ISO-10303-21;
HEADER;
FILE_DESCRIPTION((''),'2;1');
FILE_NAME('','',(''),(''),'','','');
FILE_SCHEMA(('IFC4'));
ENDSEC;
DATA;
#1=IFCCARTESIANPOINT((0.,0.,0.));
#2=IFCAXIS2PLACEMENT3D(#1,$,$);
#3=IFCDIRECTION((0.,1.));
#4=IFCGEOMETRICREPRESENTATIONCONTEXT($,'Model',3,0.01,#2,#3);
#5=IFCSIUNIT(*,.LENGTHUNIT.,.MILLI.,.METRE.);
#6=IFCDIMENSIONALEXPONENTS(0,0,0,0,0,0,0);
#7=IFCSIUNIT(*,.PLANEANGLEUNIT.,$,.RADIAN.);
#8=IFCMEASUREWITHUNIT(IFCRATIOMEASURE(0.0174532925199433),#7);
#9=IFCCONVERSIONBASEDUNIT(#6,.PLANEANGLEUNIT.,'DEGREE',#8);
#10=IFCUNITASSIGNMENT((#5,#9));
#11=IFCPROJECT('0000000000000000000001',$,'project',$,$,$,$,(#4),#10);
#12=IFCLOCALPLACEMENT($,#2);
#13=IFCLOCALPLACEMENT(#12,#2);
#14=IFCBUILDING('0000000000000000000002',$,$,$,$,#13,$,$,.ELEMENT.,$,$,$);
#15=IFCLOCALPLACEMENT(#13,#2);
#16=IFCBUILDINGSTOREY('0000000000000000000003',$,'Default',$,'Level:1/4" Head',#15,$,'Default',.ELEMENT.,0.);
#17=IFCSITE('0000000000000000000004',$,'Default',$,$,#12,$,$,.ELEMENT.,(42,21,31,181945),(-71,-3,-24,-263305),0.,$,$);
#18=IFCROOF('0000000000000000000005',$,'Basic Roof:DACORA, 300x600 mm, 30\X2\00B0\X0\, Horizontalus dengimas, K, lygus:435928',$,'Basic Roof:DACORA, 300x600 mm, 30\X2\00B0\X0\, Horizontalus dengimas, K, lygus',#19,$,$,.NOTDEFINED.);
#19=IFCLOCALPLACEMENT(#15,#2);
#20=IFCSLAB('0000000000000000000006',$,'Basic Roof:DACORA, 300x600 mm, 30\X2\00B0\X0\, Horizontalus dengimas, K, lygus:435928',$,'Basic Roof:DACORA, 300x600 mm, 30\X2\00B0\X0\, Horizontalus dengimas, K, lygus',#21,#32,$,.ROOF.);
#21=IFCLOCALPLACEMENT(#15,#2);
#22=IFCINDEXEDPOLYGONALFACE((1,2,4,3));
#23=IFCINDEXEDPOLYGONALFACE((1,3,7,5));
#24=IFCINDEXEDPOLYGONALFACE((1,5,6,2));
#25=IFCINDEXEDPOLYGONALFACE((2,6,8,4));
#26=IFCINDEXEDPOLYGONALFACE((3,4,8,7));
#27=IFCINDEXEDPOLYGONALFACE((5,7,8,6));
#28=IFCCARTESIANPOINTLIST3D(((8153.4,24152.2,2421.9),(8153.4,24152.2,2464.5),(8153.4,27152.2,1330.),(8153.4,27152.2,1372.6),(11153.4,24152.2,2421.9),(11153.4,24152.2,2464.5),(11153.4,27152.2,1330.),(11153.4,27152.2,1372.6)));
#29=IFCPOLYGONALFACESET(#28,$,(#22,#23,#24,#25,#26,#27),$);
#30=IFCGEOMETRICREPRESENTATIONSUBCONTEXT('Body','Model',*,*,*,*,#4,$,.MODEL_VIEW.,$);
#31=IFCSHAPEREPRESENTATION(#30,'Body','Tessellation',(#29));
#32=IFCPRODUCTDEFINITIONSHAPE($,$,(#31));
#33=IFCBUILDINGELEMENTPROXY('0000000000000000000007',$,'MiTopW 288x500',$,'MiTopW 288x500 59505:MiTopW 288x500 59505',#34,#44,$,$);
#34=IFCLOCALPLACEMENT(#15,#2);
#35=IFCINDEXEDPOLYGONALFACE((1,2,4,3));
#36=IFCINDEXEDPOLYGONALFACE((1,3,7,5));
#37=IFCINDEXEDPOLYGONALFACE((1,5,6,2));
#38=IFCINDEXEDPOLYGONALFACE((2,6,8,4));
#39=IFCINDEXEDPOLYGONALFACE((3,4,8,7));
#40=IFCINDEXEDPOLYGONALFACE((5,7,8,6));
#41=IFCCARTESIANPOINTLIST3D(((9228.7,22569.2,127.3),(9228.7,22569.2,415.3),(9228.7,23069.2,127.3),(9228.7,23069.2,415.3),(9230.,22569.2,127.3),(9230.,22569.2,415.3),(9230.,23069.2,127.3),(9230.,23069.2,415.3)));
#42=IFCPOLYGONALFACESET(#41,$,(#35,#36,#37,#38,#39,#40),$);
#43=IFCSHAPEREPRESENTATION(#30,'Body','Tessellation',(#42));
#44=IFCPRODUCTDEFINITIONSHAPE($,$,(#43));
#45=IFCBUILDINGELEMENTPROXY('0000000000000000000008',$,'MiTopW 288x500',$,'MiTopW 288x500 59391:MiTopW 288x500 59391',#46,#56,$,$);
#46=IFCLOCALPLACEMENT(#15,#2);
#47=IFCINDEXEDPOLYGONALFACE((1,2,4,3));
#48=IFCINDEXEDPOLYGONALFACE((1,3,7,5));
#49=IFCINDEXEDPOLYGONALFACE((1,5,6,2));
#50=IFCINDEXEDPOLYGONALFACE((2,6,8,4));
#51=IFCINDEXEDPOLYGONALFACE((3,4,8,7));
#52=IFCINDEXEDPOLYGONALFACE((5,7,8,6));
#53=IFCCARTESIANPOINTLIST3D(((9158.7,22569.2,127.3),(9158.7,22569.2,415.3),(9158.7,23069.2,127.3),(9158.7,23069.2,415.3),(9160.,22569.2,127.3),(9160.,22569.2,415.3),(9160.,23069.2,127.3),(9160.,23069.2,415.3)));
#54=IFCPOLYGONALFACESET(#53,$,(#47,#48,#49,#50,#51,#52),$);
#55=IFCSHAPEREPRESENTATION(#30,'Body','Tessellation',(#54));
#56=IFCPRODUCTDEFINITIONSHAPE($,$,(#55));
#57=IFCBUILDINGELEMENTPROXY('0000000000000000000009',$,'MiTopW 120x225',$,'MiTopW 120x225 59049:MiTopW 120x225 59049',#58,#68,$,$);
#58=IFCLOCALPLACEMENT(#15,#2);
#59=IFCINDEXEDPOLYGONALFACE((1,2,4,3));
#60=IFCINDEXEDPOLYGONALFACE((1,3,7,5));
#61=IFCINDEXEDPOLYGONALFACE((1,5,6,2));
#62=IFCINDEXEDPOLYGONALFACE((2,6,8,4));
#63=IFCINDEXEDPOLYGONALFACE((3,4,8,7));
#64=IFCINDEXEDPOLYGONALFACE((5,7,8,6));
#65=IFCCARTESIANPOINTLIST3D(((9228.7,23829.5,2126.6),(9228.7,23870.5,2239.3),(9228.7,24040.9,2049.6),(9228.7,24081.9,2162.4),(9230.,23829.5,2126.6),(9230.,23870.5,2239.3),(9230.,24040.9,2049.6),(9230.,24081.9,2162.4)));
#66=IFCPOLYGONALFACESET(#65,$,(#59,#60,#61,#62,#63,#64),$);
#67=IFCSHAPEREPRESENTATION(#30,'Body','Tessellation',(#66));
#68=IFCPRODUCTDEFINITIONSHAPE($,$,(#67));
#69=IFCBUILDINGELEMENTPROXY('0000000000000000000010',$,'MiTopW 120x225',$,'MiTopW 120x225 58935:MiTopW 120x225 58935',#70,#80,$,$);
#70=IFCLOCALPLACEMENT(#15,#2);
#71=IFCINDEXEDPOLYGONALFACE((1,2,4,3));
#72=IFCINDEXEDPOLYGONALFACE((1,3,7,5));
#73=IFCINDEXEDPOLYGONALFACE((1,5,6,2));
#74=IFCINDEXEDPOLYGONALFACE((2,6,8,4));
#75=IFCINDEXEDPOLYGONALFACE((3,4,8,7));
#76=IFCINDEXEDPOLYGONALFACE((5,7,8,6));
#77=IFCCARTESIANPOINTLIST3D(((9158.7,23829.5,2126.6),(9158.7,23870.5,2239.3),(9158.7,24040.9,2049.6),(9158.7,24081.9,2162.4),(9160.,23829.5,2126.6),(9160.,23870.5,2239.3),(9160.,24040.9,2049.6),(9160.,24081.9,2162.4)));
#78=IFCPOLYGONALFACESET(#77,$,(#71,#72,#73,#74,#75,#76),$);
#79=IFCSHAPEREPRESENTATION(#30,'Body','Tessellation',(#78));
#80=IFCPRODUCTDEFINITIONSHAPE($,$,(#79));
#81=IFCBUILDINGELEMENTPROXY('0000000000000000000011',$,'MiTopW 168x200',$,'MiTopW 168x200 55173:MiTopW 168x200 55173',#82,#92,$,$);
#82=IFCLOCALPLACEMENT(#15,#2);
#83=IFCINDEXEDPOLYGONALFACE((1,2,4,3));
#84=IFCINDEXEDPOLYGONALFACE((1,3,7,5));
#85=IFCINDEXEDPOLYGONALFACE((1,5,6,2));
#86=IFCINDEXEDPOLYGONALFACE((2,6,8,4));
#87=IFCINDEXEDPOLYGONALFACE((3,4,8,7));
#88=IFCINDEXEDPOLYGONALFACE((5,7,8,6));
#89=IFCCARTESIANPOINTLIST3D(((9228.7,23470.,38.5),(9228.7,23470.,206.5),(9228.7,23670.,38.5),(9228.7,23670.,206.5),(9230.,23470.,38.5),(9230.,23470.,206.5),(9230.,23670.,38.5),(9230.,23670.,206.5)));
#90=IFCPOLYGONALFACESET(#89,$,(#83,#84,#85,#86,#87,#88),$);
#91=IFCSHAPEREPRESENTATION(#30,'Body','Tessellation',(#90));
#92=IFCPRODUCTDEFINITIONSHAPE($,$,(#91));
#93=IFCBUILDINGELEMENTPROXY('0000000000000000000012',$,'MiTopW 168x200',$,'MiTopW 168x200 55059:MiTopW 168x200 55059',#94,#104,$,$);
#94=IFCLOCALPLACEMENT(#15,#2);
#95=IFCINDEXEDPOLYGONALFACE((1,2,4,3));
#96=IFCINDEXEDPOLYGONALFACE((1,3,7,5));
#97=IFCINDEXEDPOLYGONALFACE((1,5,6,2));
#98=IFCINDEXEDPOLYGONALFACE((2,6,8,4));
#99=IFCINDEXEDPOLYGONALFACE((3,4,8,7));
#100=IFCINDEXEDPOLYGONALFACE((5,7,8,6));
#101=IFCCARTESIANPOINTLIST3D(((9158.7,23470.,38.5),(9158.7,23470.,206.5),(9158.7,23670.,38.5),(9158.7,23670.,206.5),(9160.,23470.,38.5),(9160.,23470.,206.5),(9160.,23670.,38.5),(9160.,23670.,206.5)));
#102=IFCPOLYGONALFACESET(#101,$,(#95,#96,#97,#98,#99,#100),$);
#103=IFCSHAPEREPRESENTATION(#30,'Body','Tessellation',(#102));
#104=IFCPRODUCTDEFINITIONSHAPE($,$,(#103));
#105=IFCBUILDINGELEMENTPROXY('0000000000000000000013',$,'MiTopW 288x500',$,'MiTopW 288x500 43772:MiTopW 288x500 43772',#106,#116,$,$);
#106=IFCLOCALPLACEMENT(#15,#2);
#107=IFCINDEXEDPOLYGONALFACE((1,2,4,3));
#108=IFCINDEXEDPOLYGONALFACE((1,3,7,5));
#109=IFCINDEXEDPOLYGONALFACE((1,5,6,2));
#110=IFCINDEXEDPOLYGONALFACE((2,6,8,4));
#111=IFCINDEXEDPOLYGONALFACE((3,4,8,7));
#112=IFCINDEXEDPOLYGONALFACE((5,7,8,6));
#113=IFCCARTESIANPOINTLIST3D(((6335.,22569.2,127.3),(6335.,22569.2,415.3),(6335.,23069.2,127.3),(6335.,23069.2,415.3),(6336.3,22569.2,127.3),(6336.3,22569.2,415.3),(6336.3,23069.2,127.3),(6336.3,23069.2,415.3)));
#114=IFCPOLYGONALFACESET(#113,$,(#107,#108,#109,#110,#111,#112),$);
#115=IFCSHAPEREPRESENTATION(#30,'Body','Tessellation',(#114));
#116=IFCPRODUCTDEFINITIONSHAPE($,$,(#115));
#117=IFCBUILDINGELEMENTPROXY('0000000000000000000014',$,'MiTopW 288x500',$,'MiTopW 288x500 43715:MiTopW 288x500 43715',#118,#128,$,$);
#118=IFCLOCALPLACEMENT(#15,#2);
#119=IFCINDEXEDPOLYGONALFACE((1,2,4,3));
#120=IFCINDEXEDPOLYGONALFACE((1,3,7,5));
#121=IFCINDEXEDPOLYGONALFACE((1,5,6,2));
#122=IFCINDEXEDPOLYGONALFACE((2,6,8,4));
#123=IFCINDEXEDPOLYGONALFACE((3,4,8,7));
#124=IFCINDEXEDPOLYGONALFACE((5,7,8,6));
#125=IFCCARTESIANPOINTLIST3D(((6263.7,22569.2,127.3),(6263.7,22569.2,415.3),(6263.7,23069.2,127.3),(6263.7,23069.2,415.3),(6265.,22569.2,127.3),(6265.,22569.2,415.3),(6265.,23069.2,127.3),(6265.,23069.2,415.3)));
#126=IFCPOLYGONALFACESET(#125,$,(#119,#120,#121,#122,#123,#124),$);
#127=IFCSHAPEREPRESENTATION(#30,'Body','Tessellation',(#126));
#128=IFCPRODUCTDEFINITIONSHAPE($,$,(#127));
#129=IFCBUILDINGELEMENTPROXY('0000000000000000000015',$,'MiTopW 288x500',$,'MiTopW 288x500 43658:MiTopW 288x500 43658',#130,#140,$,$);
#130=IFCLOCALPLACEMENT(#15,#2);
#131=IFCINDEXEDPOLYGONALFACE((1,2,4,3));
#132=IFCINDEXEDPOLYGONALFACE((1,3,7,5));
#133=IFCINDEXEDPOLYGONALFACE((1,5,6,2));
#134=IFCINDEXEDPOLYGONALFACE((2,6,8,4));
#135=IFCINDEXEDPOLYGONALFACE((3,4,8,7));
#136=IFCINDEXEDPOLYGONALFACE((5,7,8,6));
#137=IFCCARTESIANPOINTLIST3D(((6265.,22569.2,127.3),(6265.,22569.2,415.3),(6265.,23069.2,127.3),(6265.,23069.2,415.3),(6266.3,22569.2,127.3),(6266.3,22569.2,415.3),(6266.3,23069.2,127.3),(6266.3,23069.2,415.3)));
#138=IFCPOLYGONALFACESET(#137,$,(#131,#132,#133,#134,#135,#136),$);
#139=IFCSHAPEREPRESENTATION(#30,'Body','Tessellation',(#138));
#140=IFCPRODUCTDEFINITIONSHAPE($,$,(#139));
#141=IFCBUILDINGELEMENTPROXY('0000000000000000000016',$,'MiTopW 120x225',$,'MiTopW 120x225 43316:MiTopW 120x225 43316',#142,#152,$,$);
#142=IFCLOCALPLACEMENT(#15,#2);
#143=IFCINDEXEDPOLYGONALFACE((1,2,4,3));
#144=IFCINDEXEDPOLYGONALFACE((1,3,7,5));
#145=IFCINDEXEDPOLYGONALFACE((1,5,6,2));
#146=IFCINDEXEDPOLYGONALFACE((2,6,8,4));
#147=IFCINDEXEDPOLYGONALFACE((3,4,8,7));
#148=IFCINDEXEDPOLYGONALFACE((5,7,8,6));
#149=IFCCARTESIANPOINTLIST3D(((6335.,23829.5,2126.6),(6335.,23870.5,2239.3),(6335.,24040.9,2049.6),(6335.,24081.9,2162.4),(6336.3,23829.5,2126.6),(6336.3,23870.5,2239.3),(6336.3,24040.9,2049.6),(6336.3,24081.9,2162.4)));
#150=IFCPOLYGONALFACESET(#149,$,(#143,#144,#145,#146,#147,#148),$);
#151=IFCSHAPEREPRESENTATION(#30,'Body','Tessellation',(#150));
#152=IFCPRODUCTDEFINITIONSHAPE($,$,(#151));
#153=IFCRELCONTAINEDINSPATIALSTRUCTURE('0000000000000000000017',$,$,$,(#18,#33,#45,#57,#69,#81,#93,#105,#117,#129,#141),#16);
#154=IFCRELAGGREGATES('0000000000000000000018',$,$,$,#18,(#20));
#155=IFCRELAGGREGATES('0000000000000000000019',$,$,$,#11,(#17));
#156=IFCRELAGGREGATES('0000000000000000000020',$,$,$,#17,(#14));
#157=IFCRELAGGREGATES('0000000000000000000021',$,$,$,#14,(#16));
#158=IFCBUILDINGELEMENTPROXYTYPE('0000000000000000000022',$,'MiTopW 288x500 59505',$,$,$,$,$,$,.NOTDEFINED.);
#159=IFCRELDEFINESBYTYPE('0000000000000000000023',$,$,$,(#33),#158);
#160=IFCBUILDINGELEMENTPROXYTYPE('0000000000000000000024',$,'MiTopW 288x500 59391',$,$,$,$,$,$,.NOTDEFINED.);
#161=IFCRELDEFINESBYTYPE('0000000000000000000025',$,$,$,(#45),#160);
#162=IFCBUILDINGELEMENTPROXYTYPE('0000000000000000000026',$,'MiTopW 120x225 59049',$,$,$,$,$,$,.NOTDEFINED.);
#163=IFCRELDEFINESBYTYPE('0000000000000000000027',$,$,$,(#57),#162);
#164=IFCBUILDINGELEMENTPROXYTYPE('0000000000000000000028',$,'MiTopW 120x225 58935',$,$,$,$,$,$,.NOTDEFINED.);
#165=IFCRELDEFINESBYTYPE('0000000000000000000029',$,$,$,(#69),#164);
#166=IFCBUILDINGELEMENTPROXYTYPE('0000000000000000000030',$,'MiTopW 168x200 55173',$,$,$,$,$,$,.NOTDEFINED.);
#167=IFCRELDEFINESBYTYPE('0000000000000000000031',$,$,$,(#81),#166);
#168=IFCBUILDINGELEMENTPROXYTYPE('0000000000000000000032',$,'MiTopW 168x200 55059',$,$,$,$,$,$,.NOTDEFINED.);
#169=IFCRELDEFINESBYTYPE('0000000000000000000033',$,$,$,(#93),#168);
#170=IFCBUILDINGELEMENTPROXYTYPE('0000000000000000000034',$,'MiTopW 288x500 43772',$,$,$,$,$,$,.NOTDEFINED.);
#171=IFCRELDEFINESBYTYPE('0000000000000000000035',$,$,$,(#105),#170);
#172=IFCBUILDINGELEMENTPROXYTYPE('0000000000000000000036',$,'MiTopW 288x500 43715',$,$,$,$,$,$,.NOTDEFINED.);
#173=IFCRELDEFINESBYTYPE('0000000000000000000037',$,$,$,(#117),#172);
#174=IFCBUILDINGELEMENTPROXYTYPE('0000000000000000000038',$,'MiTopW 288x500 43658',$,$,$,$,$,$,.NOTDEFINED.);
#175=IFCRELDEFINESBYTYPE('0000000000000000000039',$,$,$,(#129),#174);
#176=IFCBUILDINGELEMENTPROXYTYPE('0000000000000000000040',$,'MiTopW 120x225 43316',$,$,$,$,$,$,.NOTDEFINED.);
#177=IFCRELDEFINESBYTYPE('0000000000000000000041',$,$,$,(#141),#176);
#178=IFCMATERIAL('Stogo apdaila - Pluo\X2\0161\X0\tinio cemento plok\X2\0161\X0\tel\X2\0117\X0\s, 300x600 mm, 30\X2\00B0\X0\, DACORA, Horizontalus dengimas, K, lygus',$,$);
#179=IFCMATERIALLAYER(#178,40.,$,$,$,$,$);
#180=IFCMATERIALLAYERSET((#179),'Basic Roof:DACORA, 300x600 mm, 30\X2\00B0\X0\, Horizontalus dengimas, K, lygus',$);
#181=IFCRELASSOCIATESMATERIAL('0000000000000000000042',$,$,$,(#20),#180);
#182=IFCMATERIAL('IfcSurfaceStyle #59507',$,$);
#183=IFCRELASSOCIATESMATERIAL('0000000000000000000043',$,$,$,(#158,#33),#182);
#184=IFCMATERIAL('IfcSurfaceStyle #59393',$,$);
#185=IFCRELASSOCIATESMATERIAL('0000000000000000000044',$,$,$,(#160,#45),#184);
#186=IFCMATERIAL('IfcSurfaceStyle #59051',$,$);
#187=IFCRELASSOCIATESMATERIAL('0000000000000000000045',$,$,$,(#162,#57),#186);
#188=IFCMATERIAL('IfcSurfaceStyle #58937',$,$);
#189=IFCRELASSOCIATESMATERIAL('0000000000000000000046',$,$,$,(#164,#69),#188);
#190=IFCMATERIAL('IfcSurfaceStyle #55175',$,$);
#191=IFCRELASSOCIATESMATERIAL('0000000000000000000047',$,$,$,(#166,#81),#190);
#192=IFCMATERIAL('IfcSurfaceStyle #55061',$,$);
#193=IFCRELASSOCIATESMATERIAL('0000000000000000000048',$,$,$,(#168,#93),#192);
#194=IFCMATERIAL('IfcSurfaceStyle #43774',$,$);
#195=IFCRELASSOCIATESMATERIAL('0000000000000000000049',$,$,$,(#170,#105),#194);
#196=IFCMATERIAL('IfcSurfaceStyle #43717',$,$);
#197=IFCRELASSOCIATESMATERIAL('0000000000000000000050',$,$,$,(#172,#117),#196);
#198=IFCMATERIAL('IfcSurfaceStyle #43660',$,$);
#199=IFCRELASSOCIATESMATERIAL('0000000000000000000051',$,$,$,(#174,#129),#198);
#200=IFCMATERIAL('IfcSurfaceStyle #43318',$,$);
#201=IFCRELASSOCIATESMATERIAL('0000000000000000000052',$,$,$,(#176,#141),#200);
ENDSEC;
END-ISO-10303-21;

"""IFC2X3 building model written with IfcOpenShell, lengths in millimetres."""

from ifc_helpers import new_model, entity, si_unit, converted_unit, direction, frame, frame_2d, origin, origin_2d_with_axis, place, context, subcontext, project, spatial, polyline, rectangle, outline, extrude, source, transform, mapped, material, layer, layer_set, type_object, type_shapes, element, aggregate, save


model = new_model("IFC2X3")

# Units and contexts
model_context = context("Model", 3, precision=0.01, world=origin(), true_north=direction((0.0, 1.0)))
body_context = subcontext(model_context, "Body", "Model", "MODEL_VIEW")
ifc_project = project(units=[si_unit("LENGTHUNIT", "METRE", prefix="MILLI"), converted_unit("PLANEANGLEUNIT", "DEGREE", entity("IfcRatioMeasure", 0.0174532925199433), si_unit("PLANEANGLEUNIT", "RADIAN"), dimensions=[0, 0, 0, 0, 0, 0, 0])], contexts=[model_context])

# Site, building, storey
site_placement = place(None, origin())
site = spatial("IfcSite", under=ifc_project, at=site_placement, Name="Default", CompositionType="ELEMENT", RefLatitude=(42, 21, 31, 181945), RefLongitude=(-71, -3, -24, -263305), RefElevation=0.0)
building_placement = place(site_placement, origin())
building = spatial("IfcBuilding", under=site, at=building_placement, CompositionType="ELEMENT")
storey_placement = place(building_placement, origin())
storey = spatial("IfcBuildingStorey", under=building, at=storey_placement, Name="Default", ObjectType="Level:1/4\" Head", LongName="Default", CompositionType="ELEMENT", Elevation=0.0)

# Roof, slab
roof_placement = place(storey_placement, frame((8153.4, 24152.2, 1330.0)))
roof = element("IfcRoof", 1, at=roof_placement, inside=storey, Name="Basic Roof:DACORA, 300x600 mm, 30°, Horizontalus dengimas, K, lygus:435928", ObjectType="Basic Roof:DACORA, 300x600 mm, 30°, Horizontalus dengimas, K, lygus", ShapeType="NOTDEFINED")
ifc_material_1 = material(Name="Stogo apdaila - Pluoštinio cemento plokštelės, 300x600 mm, 30°, DACORA, Horizontalus dengimas, K, lygus")
ifc_layer = layer(ifc_material_1, 40.0)
ifc_layer_set = layer_set([ifc_layer], Name="Basic Roof:DACORA, 300x600 mm, 30°, Horizontalus dengimas, K, lygus")
slab_placement = place(roof_placement, origin())
slab = element("IfcSlab", 2, at=slab_placement, material=ifc_layer_set, Name="Basic Roof:DACORA, 300x600 mm, 30°, Horizontalus dengimas, K, lygus:435928", ObjectType="Basic Roof:DACORA, 300x600 mm, 30°, Horizontalus dengimas, K, lygus", PredefinedType="ROOF", context=body_context, shape_type="SweptSolid", body=[
    extrude(rectangle(XDim=3192.5, YDim=3000.0, at=frame_2d((0.0, 0.0), x_axis=(0.0, 1.0))), frame((1500.0, 1500.0, 546.0), z_axis=(0.0, 0.34202, 0.939693), x_axis=(1.0, 0.0, 0.0)), (0.0, -0.34202, 0.939693), 42.6),
])
aggregate(roof, [slab])

# Building element proxies
ifc_material_2 = material(Name="IfcSurfaceStyle #59507")
building_element_proxy_type_1 = type_object("IfcBuildingElementProxyType", Name="MiTopW 288x500 59505", PredefinedType="NOTDEFINED", material=ifc_material_2)
shared_shape_1 = source(origin(), body_context, "Body", "SweptSolid", [
    extrude(rectangle(XDim=500.0, YDim=288.0, at=origin_2d_with_axis()), frame((250.0, 144.0, 0.0), z_axis=(0.0, 0.0, 1.0), x_axis=(-1.0, 0.0, 0.0)), (0.0, 0.0, 1.0), 1.3),
])
type_shapes(building_element_proxy_type_1, [shared_shape_1])
proxy_1_placement = place(building_placement, frame((9230.0, 23069.2, 127.3), z_axis=(-1.0, 0.0, 0.0), x_axis=(0.0, -1.0, 0.0)))
element("IfcBuildingElementProxy", 3, at=proxy_1_placement, inside=storey, type_object=building_element_proxy_type_1, material=ifc_material_2, Name="MiTopW 288x500", ObjectType="MiTopW 288x500 59505:MiTopW 288x500 59505", context=body_context, shape_type="MappedRepresentation", body=[
    mapped(shared_shape_1, transform((0.0, 0.0, 0.0), scale=1.0)),
])
ifc_material_3 = material(Name="IfcSurfaceStyle #59393")
building_element_proxy_type_2 = type_object("IfcBuildingElementProxyType", Name="MiTopW 288x500 59391", PredefinedType="NOTDEFINED", material=ifc_material_3)
shared_shape_2 = source(origin(), body_context, "Body", "SweptSolid", [
    extrude(rectangle(XDim=500.0, YDim=288.0, at=origin_2d_with_axis()), frame((250.0, 144.0, 0.0), z_axis=(0.0, 0.0, 1.0), x_axis=(-1.0, 0.0, 0.0)), (0.0, 0.0, 1.0), 1.3),
])
type_shapes(building_element_proxy_type_2, [shared_shape_2])
proxy_2_placement = place(building_placement, frame((9160.0, 23069.2, 127.3), z_axis=(-1.0, 0.0, 0.0), x_axis=(0.0, -1.0, 0.0)))
element("IfcBuildingElementProxy", 4, at=proxy_2_placement, inside=storey, type_object=building_element_proxy_type_2, material=ifc_material_3, Name="MiTopW 288x500", ObjectType="MiTopW 288x500 59391:MiTopW 288x500 59391", context=body_context, shape_type="MappedRepresentation", body=[
    mapped(shared_shape_2, transform((0.0, 0.0, 0.0), scale=1.0)),
])
ifc_material_4 = material(Name="IfcSurfaceStyle #59051")
building_element_proxy_type_3 = type_object("IfcBuildingElementProxyType", Name="MiTopW 120x225 59049", PredefinedType="NOTDEFINED", material=ifc_material_4)
shared_shape_3 = source(origin(), body_context, "Body", "SweptSolid", [
    extrude(outline(polyline([(-112.5, -60.0), (112.5, -60.0), (112.5, 60.0), (-112.5, 60.0), (-112.5, -60.0)])), frame((112.5, 60.0, 0.0), z_axis=(0.0, 0.0, 1.0), x_axis=(-1.0, 0.0, 0.0)), (0.0, 0.0, 1.0), 1.3),
])
type_shapes(building_element_proxy_type_3, [shared_shape_3])
proxy_3_placement = place(building_placement, frame((9230.0, 24040.9, 2049.6), z_axis=(-1.0, 0.0, 0.0), x_axis=(0.0, -0.939693, 0.34202)))
element("IfcBuildingElementProxy", 5, at=proxy_3_placement, inside=storey, type_object=building_element_proxy_type_3, material=ifc_material_4, Name="MiTopW 120x225", ObjectType="MiTopW 120x225 59049:MiTopW 120x225 59049", context=body_context, shape_type="MappedRepresentation", body=[
    mapped(shared_shape_3, transform((0.0, 0.0, 0.0), scale=1.0)),
])
ifc_material_5 = material(Name="IfcSurfaceStyle #58937")
building_element_proxy_type_4 = type_object("IfcBuildingElementProxyType", Name="MiTopW 120x225 58935", PredefinedType="NOTDEFINED", material=ifc_material_5)
shared_shape_4 = source(origin(), body_context, "Body", "SweptSolid", [
    extrude(outline(polyline([(-112.5, -60.0), (112.5, -60.0), (112.5, 60.0), (-112.5, 60.0), (-112.5, -60.0)])), frame((112.5, 60.0, 0.0), z_axis=(0.0, 0.0, 1.0), x_axis=(-1.0, 0.0, 0.0)), (0.0, 0.0, 1.0), 1.3),
])
type_shapes(building_element_proxy_type_4, [shared_shape_4])
proxy_4_placement = place(building_placement, frame((9160.0, 24040.9, 2049.6), z_axis=(-1.0, 0.0, 0.0), x_axis=(0.0, -0.939693, 0.34202)))
element("IfcBuildingElementProxy", 6, at=proxy_4_placement, inside=storey, type_object=building_element_proxy_type_4, material=ifc_material_5, Name="MiTopW 120x225", ObjectType="MiTopW 120x225 58935:MiTopW 120x225 58935", context=body_context, shape_type="MappedRepresentation", body=[
    mapped(shared_shape_4, transform((0.0, 0.0, 0.0), scale=1.0)),
])
ifc_material_6 = material(Name="IfcSurfaceStyle #55175")
building_element_proxy_type_5 = type_object("IfcBuildingElementProxyType", Name="MiTopW 168x200 55173", PredefinedType="NOTDEFINED", material=ifc_material_6)
shared_shape_5 = source(origin(), body_context, "Body", "SweptSolid", [
    extrude(rectangle(XDim=200.0, YDim=168.0, at=origin_2d_with_axis()), frame((100.0, 84.0, 0.0), z_axis=(0.0, 0.0, 1.0), x_axis=(-1.0, 0.0, 0.0)), (0.0, 0.0, 1.0), 1.3),
])
type_shapes(building_element_proxy_type_5, [shared_shape_5])
proxy_5_placement = place(building_placement, frame((9230.0, 23470.0, 206.5), z_axis=(-1.0, 0.0, 0.0), x_axis=(0.0, 1.0, 0.0)))
element("IfcBuildingElementProxy", 7, at=proxy_5_placement, inside=storey, type_object=building_element_proxy_type_5, material=ifc_material_6, Name="MiTopW 168x200", ObjectType="MiTopW 168x200 55173:MiTopW 168x200 55173", context=body_context, shape_type="MappedRepresentation", body=[
    mapped(shared_shape_5, transform((0.0, 0.0, 0.0), scale=1.0)),
])
ifc_material_7 = material(Name="IfcSurfaceStyle #55061")
building_element_proxy_type_6 = type_object("IfcBuildingElementProxyType", Name="MiTopW 168x200 55059", PredefinedType="NOTDEFINED", material=ifc_material_7)
shared_shape_6 = source(origin(), body_context, "Body", "SweptSolid", [
    extrude(rectangle(XDim=200.0, YDim=168.0, at=origin_2d_with_axis()), frame((100.0, 84.0, 0.0), z_axis=(0.0, 0.0, 1.0), x_axis=(-1.0, 0.0, 0.0)), (0.0, 0.0, 1.0), 1.3),
])
type_shapes(building_element_proxy_type_6, [shared_shape_6])
proxy_6_placement = place(building_placement, frame((9160.0, 23470.0, 206.5), z_axis=(-1.0, 0.0, 0.0), x_axis=(0.0, 1.0, 0.0)))
element("IfcBuildingElementProxy", 8, at=proxy_6_placement, inside=storey, type_object=building_element_proxy_type_6, material=ifc_material_7, Name="MiTopW 168x200", ObjectType="MiTopW 168x200 55059:MiTopW 168x200 55059", context=body_context, shape_type="MappedRepresentation", body=[
    mapped(shared_shape_6, transform((0.0, 0.0, 0.0), scale=1.0)),
])
ifc_material_8 = material(Name="IfcSurfaceStyle #43774")
building_element_proxy_type_7 = type_object("IfcBuildingElementProxyType", Name="MiTopW 288x500 43772", PredefinedType="NOTDEFINED", material=ifc_material_8)
shared_shape_7 = source(origin(), body_context, "Body", "SweptSolid", [
    extrude(rectangle(XDim=500.0, YDim=288.0, at=origin_2d_with_axis()), frame((250.0, 144.0, 0.0), z_axis=(0.0, 0.0, 1.0), x_axis=(-1.0, 0.0, 0.0)), (0.0, 0.0, 1.0), 1.3),
])
type_shapes(building_element_proxy_type_7, [shared_shape_7])
proxy_7_placement = place(building_placement, frame((6336.3, 23069.2, 127.3), z_axis=(-1.0, 0.0, 0.0), x_axis=(0.0, -1.0, 0.0)))
element("IfcBuildingElementProxy", 9, at=proxy_7_placement, inside=storey, type_object=building_element_proxy_type_7, material=ifc_material_8, Name="MiTopW 288x500", ObjectType="MiTopW 288x500 43772:MiTopW 288x500 43772", context=body_context, shape_type="MappedRepresentation", body=[
    mapped(shared_shape_7, transform((0.0, 0.0, 0.0), scale=1.0)),
])
ifc_material_9 = material(Name="IfcSurfaceStyle #43717")
building_element_proxy_type_8 = type_object("IfcBuildingElementProxyType", Name="MiTopW 288x500 43715", PredefinedType="NOTDEFINED", material=ifc_material_9)
shared_shape_8 = source(origin(), body_context, "Body", "SweptSolid", [
    extrude(rectangle(XDim=500.0, YDim=288.0, at=origin_2d_with_axis()), frame((250.0, 144.0, 0.0), z_axis=(0.0, 0.0, 1.0), x_axis=(-1.0, 0.0, 0.0)), (0.0, 0.0, 1.0), 1.3),
])
type_shapes(building_element_proxy_type_8, [shared_shape_8])
proxy_8_placement = place(building_placement, frame((6265.0, 23069.2, 127.3), z_axis=(-1.0, 0.0, 0.0), x_axis=(0.0, -1.0, 0.0)))
element("IfcBuildingElementProxy", 10, at=proxy_8_placement, inside=storey, type_object=building_element_proxy_type_8, material=ifc_material_9, Name="MiTopW 288x500", ObjectType="MiTopW 288x500 43715:MiTopW 288x500 43715", context=body_context, shape_type="MappedRepresentation", body=[
    mapped(shared_shape_8, transform((0.0, 0.0, 0.0), scale=1.0)),
])
ifc_material_10 = material(Name="IfcSurfaceStyle #43660")
building_element_proxy_type_9 = type_object("IfcBuildingElementProxyType", Name="MiTopW 288x500 43658", PredefinedType="NOTDEFINED", material=ifc_material_10)
shared_shape_9 = source(origin(), body_context, "Body", "SweptSolid", [
    extrude(rectangle(XDim=500.0, YDim=288.0, at=origin_2d_with_axis()), frame((250.0, 144.0, 0.0), z_axis=(0.0, 0.0, 1.0), x_axis=(-1.0, 0.0, 0.0)), (0.0, 0.0, 1.0), 1.3),
])
type_shapes(building_element_proxy_type_9, [shared_shape_9])
proxy_9_placement = place(building_placement, frame((6266.3, 23069.2, 127.3), z_axis=(-1.0, 0.0, 0.0), x_axis=(0.0, -1.0, 0.0)))
element("IfcBuildingElementProxy", 11, at=proxy_9_placement, inside=storey, type_object=building_element_proxy_type_9, material=ifc_material_10, Name="MiTopW 288x500", ObjectType="MiTopW 288x500 43658:MiTopW 288x500 43658", context=body_context, shape_type="MappedRepresentation", body=[
    mapped(shared_shape_9, transform((0.0, 0.0, 0.0), scale=1.0)),
])
ifc_material_11 = material(Name="IfcSurfaceStyle #43318")
building_element_proxy_type_10 = type_object("IfcBuildingElementProxyType", Name="MiTopW 120x225 43316", PredefinedType="NOTDEFINED", material=ifc_material_11)
shared_shape_10 = source(origin(), body_context, "Body", "SweptSolid", [
    extrude(outline(polyline([(-112.5, -60.0), (112.5, -60.0), (112.5, 60.0), (-112.5, 60.0), (-112.5, -60.0)])), frame((112.5, 60.0, 0.0), z_axis=(0.0, 0.0, 1.0), x_axis=(-1.0, 0.0, 0.0)), (0.0, 0.0, 1.0), 1.3),
])
type_shapes(building_element_proxy_type_10, [shared_shape_10])
proxy_10_placement = place(building_placement, frame((6336.3, 24040.9, 2049.6), z_axis=(-1.0, 0.0, 0.0), x_axis=(0.0, -0.939693, 0.34202)))
element("IfcBuildingElementProxy", 12, at=proxy_10_placement, inside=storey, type_object=building_element_proxy_type_10, material=ifc_material_11, Name="MiTopW 120x225", ObjectType="MiTopW 120x225 43316:MiTopW 120x225 43316", context=body_context, shape_type="MappedRepresentation", body=[
    mapped(shared_shape_10, transform((0.0, 0.0, 0.0), scale=1.0)),
])

save(model, "model.ifc")
